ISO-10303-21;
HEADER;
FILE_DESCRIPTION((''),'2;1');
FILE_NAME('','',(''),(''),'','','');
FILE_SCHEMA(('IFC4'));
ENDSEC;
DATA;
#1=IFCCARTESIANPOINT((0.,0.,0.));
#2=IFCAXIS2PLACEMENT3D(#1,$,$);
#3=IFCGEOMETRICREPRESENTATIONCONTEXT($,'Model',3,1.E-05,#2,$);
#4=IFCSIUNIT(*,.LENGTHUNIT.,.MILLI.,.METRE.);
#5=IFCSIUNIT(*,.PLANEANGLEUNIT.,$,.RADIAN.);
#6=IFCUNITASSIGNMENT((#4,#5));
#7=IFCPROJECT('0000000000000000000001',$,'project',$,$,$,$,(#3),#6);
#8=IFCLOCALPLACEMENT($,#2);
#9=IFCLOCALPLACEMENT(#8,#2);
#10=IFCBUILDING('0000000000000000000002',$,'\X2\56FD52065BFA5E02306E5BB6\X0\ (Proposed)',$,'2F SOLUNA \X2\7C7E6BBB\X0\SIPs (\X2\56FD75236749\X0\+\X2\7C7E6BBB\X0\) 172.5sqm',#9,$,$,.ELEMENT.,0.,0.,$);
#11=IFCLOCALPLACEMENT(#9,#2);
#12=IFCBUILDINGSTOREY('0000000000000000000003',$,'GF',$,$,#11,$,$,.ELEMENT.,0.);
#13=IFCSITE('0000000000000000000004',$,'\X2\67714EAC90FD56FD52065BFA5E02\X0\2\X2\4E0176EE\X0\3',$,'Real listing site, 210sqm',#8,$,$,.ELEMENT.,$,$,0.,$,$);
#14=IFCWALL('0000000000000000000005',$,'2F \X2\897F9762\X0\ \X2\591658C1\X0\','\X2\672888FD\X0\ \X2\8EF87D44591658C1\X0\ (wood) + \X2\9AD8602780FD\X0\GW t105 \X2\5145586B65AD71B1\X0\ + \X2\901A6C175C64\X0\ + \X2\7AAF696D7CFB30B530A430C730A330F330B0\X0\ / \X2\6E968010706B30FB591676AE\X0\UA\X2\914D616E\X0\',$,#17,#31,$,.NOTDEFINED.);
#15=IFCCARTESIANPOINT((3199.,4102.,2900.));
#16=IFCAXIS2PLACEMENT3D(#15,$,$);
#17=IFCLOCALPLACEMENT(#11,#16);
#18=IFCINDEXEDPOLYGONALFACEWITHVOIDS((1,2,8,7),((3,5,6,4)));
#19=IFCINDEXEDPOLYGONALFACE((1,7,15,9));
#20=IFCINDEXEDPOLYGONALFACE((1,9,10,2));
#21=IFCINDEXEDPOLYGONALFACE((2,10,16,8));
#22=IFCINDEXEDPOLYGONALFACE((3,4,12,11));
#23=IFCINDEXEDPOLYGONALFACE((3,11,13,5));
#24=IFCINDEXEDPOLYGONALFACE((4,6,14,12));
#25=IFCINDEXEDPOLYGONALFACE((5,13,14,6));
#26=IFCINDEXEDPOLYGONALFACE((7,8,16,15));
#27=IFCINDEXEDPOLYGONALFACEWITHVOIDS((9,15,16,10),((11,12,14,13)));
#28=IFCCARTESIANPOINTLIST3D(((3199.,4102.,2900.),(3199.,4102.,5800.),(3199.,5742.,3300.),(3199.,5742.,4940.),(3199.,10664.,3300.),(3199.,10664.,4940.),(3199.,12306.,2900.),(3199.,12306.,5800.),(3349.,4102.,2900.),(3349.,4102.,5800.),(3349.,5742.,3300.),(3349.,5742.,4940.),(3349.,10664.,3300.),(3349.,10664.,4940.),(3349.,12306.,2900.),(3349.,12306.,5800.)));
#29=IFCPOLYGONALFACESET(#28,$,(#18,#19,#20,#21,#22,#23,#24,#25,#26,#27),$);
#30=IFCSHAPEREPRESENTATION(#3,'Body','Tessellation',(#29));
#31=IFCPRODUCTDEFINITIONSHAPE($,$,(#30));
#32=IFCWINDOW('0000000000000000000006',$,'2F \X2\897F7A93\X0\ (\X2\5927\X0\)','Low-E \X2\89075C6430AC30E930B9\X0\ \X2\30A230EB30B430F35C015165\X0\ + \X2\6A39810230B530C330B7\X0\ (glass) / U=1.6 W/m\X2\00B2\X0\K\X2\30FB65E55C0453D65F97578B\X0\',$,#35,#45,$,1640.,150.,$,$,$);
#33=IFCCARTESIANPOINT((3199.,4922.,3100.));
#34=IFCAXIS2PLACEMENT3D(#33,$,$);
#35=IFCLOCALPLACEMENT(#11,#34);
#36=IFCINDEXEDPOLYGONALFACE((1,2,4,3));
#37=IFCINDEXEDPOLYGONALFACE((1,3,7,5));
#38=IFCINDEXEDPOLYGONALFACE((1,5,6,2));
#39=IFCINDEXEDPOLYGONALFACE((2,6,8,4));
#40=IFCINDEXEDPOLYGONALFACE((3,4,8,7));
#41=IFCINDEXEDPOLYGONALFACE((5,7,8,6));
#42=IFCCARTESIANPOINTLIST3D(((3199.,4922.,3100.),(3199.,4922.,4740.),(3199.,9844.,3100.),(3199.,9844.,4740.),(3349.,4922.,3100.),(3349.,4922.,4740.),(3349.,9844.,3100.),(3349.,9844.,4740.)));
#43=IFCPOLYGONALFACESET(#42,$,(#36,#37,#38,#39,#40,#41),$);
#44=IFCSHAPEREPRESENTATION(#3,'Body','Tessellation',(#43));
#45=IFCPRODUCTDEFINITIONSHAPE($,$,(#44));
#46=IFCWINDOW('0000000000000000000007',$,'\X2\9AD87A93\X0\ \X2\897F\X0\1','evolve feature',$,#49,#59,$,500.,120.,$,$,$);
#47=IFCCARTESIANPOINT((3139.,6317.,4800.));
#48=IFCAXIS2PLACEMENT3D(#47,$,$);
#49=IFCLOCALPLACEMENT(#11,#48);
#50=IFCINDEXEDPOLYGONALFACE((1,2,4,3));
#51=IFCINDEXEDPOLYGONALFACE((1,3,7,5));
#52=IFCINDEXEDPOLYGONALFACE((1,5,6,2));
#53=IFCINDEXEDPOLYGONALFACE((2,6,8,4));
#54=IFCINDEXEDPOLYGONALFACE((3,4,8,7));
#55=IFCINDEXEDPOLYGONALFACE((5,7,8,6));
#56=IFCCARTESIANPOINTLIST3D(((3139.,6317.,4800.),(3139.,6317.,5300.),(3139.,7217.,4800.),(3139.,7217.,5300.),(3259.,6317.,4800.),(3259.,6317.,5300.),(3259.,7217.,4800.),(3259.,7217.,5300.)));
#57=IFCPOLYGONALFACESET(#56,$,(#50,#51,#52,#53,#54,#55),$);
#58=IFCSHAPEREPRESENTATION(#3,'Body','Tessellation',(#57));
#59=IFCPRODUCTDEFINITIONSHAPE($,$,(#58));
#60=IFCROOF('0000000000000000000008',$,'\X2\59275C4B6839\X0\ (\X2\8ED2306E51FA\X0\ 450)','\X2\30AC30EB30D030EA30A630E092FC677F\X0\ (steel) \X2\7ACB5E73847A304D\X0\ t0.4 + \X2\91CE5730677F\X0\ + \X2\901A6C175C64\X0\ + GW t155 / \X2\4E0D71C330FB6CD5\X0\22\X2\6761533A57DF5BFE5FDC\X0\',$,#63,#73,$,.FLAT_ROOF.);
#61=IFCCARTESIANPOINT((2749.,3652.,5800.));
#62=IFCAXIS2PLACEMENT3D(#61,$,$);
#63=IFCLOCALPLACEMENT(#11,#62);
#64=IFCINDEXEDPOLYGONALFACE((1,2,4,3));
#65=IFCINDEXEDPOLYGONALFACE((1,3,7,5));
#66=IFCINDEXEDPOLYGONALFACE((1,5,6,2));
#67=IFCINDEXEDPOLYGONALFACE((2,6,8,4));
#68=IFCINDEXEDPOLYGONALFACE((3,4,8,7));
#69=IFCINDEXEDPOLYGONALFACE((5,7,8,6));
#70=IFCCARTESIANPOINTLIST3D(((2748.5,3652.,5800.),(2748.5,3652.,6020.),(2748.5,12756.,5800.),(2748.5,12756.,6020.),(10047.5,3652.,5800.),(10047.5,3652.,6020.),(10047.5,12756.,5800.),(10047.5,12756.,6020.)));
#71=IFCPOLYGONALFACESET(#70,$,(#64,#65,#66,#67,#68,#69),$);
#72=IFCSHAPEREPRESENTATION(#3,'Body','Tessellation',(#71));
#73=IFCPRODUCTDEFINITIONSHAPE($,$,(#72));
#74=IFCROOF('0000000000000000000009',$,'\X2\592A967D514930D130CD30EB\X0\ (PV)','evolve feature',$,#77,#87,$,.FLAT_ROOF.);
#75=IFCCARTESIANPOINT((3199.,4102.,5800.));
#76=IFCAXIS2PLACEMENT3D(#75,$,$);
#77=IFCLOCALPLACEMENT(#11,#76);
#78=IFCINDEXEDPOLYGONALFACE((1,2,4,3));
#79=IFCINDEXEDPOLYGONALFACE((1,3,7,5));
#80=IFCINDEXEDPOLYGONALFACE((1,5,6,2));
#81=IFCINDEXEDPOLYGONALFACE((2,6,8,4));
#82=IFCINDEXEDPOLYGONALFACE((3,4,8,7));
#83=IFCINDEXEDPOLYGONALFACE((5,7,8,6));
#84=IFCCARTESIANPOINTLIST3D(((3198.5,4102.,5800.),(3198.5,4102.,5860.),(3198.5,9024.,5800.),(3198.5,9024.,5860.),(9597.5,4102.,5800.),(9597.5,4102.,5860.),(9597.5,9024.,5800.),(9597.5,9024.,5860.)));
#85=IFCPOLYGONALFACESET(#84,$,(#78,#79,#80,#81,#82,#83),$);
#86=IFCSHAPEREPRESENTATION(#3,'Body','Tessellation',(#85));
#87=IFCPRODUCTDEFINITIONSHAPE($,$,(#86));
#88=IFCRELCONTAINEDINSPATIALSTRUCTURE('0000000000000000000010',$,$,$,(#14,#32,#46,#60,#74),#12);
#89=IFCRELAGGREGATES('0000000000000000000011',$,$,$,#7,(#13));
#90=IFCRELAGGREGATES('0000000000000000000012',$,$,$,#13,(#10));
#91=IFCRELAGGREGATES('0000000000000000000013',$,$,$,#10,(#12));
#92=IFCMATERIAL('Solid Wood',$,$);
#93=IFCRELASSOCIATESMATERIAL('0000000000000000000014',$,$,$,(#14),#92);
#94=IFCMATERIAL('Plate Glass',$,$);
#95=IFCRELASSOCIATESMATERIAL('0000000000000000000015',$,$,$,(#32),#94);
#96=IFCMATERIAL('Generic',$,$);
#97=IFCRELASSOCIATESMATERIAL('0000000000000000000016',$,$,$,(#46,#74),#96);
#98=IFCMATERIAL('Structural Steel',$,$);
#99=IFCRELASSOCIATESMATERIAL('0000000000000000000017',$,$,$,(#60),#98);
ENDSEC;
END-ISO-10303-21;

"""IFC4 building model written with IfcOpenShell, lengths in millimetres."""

from ifc_helpers import new_model, si_unit, frame, frame_2d, origin, place, context, project, spatial, rectangle, extrude, material, element, fill, save


model = new_model("IFC4")

# Units and contexts
model_context = context("Model", 3, precision=1e-05, world=origin())
ifc_project = project(units=[si_unit("LENGTHUNIT", "METRE", prefix="MILLI"), si_unit("PLANEANGLEUNIT", "RADIAN")], contexts=[model_context])

# Site, building, storey
site_placement = place(None, origin())
site = spatial("IfcSite", under=ifc_project, at=site_placement, Name="東京都国分寺市2丁目3", ObjectType="Real listing site, 210sqm", CompositionType="ELEMENT", RefElevation=0.0)
building_placement = place(site_placement, origin())
building = spatial("IfcBuilding", under=site, at=building_placement, Name="国分寺市の家 (Proposed)", ObjectType="2F SOLUNA 籾殻SIPs (国産杉+籾殻) 172.5sqm", CompositionType="ELEMENT", ElevationOfRefHeight=0.0, ElevationOfTerrain=0.0)
storey_placement = place(building_placement, origin())
storey = spatial("IfcBuildingStorey", under=building, at=storey_placement, Name="GF", CompositionType="ELEMENT", Elevation=0.0)

# Shared definitions
ifc_material_1 = material(Name="Solid Wood")
ifc_material_2 = material(Name="Generic")

# Shared definitions
ifc_material_3 = material(Name="Plate Glass")

# Wall, openings, windows
wall_1_placement = place(storey_placement, frame((3199.0, 4102.0, 2900.0)))
wall_1 = element("IfcWall", 1, at=wall_1_placement, inside=storey, material=ifc_material_1, Name="2F 西面 外壁", Description="木製 軸組外壁 (wood) + 高性能GW t105 充填断熱 + 通気層 + 窯業系サイディング / 準耐火・外皮UA配慮", PredefinedType="NOTDEFINED", context=model_context, shape_type="SweptSolid", body=[
    extrude(rectangle(XDim=150.0, YDim=8204.0, at=frame_2d((75.0, 4102.0))), frame((3199.0, 4102.0, 2900.0)), (0.0, 0.0, 1.0), 2900.0),
])
opening_1_placement = place(storey_placement, frame((3199.0, 4922.0, 3100.0)))
opening_1 = element("IfcOpeningElement", 2, at=opening_1_placement, cuts=wall_1, PredefinedType="NOTDEFINED", context=model_context, shape_type="SweptSolid", body=[
    extrude(rectangle(XDim=150.0, YDim=4922.0, at=frame_2d((75.0, 2461.0))), frame((3199.0, 4922.0, 3100.0)), (0.0, 0.0, 1.0), 1640.0),
])
opening_2_placement = place(storey_placement, frame((3139.0, 6317.0, 4800.0)))
opening_2 = element("IfcOpeningElement", 3, at=opening_2_placement, cuts=wall_1, PredefinedType="NOTDEFINED", context=model_context, shape_type="SweptSolid", body=[
    extrude(rectangle(XDim=120.0, YDim=900.0, at=frame_2d((60.0, 450.0))), frame((3139.0, 6317.0, 4800.0)), (0.0, 0.0, 1.0), 500.0),
])
window_1_placement = place(storey_placement, frame((3199.0, 4922.0, 3100.0)))
window_1 = element("IfcWindow", 4, at=window_1_placement, inside=storey, material=ifc_material_3, Name="2F 西窓 (大)", Description="Low-E 複層ガラス アルゴン封入 + 樹脂サッシ (glass) / U=1.6 W/m²K・日射取得型", OverallHeight=1640.0, OverallWidth=150.0, context=model_context, shape_type="SweptSolid", body=[
    extrude(rectangle(XDim=150.0, YDim=4922.0, at=frame_2d((75.0, 2461.0))), frame((3199.0, 4922.0, 3100.0)), (0.0, 0.0, 1.0), 1640.0),
])
fill(opening_1, window_1)
window_2_placement = place(storey_placement, frame((3139.0, 6317.0, 4800.0)))
window_2 = element("IfcWindow", 5, at=window_2_placement, inside=storey, material=ifc_material_2, Name="高窓 西1", Description="evolve feature", OverallHeight=500.0, OverallWidth=120.0, context=model_context, shape_type="SweptSolid", body=[
    extrude(rectangle(XDim=120.0, YDim=900.0, at=frame_2d((60.0, 450.0))), frame((3139.0, 6317.0, 4800.0)), (0.0, 0.0, 1.0), 500.0),
])
fill(opening_2, window_2)

# Roofs
ifc_material_4 = material(Name="Structural Steel")
roof_1_placement = place(storey_placement, frame((2749.0, 3652.0, 5800.0)))
element("IfcRoof", 6, at=roof_1_placement, inside=storey, material=ifc_material_4, Name="大屋根 (軒の出 450)", Description="ガルバリウム鋼板 (steel) 立平葺き t0.4 + 野地板 + 通気層 + GW t155 / 不燃・法22条区域対応", PredefinedType="FLAT_ROOF", context=model_context, shape_type="SweptSolid", body=[
    extrude(rectangle(XDim=7299.0, YDim=9104.0, at=frame_2d((3649.0, 4552.0))), frame((2749.0, 3652.0, 5800.0)), (0.0, 0.0, 1.0), 220.0),
])
roof_2_placement = place(storey_placement, frame((3199.0, 4102.0, 5800.0)))
element("IfcRoof", 7, at=roof_2_placement, inside=storey, material=ifc_material_2, Name="太陽光パネル (PV)", Description="evolve feature", PredefinedType="FLAT_ROOF", context=model_context, shape_type="SweptSolid", body=[
    extrude(rectangle(XDim=6399.0, YDim=4922.0, at=frame_2d((3199.0, 2461.0))), frame((3199.0, 4102.0, 5800.0)), (0.0, 0.0, 1.0), 60.0),
])

save(model, "model.ifc")
